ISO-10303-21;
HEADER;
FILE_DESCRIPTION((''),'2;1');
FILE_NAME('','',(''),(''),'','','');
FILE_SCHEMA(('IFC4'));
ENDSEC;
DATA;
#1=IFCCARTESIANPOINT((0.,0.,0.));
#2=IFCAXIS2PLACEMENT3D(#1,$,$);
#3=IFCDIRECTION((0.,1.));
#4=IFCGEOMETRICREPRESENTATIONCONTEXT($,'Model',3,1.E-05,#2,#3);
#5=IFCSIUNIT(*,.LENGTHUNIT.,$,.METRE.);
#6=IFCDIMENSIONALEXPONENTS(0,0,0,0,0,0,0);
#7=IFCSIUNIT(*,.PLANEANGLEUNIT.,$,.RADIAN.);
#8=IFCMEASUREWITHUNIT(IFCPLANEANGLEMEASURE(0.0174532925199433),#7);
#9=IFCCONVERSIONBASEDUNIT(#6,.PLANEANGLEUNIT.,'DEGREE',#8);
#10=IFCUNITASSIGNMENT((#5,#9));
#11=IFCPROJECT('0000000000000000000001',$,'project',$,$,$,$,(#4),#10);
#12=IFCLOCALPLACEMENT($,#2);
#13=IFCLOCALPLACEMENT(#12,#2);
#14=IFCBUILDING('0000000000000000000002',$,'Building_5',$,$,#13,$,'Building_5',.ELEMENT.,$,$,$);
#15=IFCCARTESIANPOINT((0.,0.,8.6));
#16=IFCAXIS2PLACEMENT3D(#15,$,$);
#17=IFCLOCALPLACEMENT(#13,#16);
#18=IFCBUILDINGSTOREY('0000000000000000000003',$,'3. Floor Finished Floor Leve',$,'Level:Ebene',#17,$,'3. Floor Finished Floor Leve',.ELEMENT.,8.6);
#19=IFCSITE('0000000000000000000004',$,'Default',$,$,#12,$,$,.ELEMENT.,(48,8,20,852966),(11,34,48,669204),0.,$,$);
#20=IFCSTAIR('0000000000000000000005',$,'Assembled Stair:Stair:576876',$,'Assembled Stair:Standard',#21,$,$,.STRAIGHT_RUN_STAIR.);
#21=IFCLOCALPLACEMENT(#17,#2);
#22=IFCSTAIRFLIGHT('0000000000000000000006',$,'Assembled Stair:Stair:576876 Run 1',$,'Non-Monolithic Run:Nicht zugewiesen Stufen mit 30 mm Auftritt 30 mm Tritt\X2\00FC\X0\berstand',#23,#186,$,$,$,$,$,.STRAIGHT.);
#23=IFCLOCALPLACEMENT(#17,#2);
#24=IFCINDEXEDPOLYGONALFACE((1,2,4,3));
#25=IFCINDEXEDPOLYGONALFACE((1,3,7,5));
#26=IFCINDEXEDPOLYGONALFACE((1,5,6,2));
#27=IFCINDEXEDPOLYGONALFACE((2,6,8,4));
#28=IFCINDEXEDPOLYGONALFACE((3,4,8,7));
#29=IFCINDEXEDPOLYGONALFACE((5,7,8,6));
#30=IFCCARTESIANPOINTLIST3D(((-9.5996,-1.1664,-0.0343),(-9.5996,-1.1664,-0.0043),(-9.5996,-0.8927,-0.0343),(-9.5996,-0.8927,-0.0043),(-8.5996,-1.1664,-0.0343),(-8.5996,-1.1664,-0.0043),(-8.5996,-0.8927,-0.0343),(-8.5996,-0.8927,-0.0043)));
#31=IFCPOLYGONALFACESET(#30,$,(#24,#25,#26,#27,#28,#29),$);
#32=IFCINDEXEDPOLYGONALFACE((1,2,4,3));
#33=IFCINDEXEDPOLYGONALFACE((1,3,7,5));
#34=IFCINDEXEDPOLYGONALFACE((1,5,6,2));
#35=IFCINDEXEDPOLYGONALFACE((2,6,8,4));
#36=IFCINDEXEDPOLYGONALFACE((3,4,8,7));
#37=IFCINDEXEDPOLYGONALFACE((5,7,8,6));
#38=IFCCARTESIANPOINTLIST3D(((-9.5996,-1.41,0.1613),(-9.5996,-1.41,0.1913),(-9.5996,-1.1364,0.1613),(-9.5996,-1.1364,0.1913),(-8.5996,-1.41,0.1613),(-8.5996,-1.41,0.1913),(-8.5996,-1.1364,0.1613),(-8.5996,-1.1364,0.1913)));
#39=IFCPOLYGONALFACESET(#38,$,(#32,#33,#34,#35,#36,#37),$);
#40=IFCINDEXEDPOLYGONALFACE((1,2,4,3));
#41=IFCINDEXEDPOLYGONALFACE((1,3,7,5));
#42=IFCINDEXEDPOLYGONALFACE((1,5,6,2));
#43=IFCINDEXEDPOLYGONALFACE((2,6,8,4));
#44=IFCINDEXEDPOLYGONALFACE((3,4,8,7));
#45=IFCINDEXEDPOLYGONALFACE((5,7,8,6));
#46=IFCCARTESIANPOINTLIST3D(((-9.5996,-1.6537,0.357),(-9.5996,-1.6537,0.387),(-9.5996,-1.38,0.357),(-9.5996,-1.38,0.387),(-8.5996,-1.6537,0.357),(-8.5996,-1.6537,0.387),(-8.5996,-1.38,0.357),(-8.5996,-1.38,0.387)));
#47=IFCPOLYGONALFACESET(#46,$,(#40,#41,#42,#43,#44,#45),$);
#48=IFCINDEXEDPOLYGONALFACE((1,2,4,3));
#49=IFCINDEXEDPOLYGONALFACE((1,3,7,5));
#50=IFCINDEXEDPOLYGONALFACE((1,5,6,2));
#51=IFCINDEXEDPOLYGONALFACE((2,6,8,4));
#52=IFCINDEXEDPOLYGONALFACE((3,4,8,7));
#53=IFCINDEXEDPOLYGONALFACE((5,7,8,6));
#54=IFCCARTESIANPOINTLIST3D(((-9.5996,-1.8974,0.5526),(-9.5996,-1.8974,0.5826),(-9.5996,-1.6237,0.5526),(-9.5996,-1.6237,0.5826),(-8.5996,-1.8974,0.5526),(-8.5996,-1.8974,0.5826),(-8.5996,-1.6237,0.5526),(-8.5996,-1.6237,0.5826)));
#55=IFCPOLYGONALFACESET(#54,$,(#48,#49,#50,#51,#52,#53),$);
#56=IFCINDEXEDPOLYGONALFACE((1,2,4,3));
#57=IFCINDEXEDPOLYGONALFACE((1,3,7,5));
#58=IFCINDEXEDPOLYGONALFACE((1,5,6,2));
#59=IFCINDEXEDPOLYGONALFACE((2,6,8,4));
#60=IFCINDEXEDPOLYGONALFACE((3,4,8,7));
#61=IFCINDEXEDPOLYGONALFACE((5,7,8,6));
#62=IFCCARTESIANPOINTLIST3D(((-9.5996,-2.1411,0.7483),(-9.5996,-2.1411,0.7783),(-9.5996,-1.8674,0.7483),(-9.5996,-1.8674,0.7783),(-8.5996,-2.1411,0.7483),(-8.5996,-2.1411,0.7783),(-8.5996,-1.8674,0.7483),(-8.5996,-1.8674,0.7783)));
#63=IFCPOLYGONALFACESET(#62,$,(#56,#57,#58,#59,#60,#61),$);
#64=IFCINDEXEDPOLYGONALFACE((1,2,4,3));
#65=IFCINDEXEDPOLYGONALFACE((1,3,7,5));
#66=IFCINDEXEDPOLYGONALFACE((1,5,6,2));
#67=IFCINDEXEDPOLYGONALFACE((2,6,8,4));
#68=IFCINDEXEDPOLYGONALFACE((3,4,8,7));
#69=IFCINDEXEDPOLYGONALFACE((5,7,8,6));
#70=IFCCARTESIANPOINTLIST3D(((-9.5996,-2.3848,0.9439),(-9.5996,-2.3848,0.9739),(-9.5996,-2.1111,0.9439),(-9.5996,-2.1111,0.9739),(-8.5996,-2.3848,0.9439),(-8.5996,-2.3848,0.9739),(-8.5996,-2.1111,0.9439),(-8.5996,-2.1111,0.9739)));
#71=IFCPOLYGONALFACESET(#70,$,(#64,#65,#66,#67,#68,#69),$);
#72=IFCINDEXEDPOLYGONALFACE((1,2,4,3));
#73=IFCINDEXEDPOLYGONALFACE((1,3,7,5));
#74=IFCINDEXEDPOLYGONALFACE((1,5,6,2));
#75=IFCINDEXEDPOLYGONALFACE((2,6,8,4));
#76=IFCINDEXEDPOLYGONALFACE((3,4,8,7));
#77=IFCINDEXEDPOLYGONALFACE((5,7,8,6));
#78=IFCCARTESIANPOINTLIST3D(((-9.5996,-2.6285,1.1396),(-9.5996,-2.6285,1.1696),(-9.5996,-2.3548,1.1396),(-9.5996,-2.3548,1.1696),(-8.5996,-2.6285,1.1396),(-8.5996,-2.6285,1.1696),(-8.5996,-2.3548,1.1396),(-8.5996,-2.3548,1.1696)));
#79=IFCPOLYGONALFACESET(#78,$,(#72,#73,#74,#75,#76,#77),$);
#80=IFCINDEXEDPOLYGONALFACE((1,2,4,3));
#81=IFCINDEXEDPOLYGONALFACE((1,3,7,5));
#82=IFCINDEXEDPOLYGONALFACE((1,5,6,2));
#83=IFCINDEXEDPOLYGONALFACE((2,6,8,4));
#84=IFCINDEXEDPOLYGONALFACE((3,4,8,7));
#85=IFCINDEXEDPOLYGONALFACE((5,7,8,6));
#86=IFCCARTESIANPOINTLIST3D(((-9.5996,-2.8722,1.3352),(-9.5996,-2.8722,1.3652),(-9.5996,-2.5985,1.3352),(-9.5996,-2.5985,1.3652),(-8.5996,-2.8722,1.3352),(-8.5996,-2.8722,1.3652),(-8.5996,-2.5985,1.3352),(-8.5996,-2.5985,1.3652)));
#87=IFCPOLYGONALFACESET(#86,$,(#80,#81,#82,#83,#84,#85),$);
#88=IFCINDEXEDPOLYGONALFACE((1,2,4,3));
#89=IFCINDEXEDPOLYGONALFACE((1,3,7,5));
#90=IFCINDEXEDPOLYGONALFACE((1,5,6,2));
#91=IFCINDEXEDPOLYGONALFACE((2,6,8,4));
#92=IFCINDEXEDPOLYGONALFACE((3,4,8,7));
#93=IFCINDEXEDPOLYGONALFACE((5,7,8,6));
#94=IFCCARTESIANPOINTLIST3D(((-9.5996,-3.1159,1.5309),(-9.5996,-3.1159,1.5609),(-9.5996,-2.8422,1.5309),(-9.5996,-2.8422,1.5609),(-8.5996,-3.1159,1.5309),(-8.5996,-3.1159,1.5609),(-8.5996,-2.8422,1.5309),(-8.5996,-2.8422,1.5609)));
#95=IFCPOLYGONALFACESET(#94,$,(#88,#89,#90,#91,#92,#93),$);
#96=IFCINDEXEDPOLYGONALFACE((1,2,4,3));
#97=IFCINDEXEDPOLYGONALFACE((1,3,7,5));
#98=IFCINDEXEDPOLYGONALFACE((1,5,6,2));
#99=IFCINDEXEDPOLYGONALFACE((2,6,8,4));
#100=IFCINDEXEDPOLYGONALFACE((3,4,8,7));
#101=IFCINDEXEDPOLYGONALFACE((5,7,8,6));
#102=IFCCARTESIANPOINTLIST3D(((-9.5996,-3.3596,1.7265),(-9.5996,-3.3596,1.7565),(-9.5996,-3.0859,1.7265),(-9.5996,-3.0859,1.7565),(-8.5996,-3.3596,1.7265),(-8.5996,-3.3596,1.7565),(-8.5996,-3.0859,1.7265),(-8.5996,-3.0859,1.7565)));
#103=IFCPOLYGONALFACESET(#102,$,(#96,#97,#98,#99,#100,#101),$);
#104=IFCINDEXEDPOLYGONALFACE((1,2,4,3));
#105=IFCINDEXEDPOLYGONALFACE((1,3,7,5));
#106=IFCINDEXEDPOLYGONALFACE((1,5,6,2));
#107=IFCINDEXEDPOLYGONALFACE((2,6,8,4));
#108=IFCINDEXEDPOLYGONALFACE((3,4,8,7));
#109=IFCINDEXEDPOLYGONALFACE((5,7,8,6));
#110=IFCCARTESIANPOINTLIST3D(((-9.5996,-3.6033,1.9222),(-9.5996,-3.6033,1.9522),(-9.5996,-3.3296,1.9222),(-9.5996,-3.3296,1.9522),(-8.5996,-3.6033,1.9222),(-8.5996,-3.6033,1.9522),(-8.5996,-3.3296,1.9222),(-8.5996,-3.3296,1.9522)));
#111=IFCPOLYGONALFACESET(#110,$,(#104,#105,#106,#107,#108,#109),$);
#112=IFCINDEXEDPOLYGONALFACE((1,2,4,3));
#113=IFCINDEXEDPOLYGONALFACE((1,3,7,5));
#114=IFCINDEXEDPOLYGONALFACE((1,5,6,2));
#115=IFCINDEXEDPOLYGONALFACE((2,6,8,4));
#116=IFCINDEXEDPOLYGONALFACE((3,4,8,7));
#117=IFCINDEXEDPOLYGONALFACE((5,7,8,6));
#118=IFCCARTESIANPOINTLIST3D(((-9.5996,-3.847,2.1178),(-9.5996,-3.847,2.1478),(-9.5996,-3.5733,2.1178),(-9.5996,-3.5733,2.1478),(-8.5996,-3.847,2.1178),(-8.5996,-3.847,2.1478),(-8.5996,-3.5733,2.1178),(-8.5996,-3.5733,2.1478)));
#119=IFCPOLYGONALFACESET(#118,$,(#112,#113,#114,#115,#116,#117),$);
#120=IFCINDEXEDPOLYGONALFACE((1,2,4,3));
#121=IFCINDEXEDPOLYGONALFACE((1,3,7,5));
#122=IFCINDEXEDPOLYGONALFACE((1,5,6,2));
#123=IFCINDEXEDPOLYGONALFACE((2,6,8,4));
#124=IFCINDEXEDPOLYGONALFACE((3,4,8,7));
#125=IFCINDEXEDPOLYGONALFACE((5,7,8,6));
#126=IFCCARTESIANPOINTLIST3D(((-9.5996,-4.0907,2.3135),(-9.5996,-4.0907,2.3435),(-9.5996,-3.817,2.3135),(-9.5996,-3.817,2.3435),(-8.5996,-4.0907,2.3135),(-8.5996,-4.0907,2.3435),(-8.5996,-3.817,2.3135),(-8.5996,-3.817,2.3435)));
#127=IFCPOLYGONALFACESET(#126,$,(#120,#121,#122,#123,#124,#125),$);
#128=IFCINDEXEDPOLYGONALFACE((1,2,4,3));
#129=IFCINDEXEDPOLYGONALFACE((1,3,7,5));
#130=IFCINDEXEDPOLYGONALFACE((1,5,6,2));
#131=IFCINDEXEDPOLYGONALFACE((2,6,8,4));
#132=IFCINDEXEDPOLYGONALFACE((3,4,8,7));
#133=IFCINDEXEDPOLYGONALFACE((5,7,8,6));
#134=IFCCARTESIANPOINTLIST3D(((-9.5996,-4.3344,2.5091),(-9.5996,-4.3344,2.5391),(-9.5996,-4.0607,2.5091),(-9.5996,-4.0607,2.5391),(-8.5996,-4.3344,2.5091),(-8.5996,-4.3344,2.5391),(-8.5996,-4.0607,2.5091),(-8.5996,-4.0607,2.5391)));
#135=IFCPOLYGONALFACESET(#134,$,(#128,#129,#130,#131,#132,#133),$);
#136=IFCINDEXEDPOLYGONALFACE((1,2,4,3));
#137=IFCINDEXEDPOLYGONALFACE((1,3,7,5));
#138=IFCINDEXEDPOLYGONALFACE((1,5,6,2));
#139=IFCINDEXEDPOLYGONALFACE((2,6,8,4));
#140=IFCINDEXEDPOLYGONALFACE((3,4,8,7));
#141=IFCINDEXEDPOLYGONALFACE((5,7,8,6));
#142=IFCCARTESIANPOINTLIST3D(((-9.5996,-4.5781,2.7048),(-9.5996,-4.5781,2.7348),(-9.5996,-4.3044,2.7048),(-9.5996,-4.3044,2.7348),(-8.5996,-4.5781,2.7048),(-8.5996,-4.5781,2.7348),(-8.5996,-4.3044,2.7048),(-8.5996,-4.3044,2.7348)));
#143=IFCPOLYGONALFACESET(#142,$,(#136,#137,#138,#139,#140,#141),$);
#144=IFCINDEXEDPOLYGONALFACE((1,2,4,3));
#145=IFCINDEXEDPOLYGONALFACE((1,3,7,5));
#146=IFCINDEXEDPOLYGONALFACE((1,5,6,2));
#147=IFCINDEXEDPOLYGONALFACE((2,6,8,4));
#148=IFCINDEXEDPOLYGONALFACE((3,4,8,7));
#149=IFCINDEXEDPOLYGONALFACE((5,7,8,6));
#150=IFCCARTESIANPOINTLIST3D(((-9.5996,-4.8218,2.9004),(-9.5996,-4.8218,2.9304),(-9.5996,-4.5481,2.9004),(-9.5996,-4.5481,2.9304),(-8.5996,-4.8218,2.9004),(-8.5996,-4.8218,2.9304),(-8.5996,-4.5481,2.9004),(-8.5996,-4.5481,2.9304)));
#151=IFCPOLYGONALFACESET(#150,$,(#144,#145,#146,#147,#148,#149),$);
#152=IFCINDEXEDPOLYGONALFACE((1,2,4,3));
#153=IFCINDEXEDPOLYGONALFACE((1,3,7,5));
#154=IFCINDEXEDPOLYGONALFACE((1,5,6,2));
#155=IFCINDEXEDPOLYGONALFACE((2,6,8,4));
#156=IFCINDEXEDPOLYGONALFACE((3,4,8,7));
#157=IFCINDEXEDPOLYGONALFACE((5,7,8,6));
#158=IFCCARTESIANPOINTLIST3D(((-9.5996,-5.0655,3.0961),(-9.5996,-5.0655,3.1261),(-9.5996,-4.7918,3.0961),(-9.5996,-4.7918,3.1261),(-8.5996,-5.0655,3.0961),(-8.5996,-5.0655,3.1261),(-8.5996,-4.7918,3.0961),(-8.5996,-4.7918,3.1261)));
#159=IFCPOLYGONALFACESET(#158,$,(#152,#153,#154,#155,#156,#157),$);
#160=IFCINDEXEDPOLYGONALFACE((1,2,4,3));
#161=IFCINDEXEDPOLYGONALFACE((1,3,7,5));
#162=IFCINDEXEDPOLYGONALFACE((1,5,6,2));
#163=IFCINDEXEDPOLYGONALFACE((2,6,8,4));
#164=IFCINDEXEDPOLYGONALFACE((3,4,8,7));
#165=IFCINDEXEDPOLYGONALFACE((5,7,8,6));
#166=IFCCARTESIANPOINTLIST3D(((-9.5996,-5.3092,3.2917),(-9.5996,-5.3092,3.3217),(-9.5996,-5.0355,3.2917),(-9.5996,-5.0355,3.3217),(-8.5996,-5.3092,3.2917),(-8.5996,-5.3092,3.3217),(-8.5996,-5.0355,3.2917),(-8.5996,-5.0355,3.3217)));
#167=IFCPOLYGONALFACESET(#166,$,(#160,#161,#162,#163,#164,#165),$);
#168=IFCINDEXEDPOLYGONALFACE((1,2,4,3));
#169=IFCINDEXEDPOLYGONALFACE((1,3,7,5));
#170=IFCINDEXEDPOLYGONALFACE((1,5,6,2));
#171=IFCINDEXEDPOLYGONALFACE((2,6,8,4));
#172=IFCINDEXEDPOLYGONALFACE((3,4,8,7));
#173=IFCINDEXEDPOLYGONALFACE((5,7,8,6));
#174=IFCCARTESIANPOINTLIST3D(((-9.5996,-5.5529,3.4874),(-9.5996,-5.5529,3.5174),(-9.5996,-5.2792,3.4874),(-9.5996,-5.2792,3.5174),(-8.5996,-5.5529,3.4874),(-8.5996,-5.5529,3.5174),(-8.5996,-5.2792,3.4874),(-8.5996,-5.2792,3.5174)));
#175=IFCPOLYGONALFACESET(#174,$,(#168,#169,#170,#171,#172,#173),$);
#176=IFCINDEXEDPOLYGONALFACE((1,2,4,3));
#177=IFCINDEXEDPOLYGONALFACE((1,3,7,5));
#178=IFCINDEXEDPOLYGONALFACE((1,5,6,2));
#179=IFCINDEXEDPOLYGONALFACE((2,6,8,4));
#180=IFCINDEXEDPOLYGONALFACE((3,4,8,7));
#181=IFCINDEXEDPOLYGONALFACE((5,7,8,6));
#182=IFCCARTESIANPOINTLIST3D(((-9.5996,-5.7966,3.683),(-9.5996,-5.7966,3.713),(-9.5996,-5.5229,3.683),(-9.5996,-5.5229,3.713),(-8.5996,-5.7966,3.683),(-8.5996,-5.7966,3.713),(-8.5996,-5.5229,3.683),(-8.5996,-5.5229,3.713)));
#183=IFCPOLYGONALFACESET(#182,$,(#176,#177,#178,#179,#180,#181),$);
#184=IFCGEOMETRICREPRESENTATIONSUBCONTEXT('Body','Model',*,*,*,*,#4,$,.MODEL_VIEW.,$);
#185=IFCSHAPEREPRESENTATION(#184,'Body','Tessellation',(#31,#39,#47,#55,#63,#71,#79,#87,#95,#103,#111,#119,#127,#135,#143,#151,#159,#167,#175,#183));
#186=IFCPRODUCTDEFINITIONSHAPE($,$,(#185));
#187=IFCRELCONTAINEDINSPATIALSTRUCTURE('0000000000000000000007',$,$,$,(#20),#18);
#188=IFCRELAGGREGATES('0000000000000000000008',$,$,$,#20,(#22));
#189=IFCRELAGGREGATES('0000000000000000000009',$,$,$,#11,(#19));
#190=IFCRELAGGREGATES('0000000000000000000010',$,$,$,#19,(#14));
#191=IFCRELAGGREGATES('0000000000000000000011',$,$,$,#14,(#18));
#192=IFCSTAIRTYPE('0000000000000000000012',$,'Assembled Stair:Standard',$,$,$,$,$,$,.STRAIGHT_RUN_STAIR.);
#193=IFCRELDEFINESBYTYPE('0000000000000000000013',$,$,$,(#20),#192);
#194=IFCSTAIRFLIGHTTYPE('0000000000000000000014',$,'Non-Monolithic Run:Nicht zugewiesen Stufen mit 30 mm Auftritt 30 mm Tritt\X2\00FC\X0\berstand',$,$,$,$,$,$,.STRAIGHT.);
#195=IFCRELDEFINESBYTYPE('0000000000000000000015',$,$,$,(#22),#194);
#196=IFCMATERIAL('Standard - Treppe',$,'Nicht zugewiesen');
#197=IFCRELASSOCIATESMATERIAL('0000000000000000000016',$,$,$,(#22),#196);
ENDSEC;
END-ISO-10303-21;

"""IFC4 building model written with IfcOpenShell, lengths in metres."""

from ifc_helpers import new_model, entity, si_unit, converted_unit, direction, frame, origin, place, context, subcontext, project, spatial, indexed_curve, outline, extrude, material, type_object, element, aggregate, save


model = new_model("IFC4")

# Units and contexts
model_context = context("Model", 3, precision=1e-05, world=origin(), true_north=direction((0.0, 1.0)))
body_context = subcontext(model_context, "Body", "Model", "MODEL_VIEW")
ifc_project = project(units=[si_unit("LENGTHUNIT", "METRE"), converted_unit("PLANEANGLEUNIT", "DEGREE", entity("IfcPlaneAngleMeasure", 0.0174532925199433), si_unit("PLANEANGLEUNIT", "RADIAN"), dimensions=[0, 0, 0, 0, 0, 0, 0])], contexts=[model_context])

# Site, building, storey
site_placement = place(None, origin())
site = spatial("IfcSite", under=ifc_project, at=site_placement, Name="Default", CompositionType="ELEMENT", RefLatitude=(48, 8, 20, 852966), RefLongitude=(11, 34, 48, 669204), RefElevation=0.0)
building_placement = place(site_placement, origin())
building = spatial("IfcBuilding", under=site, at=building_placement, Name="Building_5", LongName="Building_5", CompositionType="ELEMENT")
storey_placement = place(building_placement, frame((0.0, 0.0, 8.6)))
storey = spatial("IfcBuildingStorey", under=building, at=storey_placement, Name="3. Floor Finished Floor Leve", ObjectType="Level:Ebene", LongName="3. Floor Finished Floor Leve", CompositionType="ELEMENT", Elevation=8.6)

# Stair, stair flight
stair_type_1 = type_object("IfcStairType", Name="Assembled Stair:Standard", PredefinedType="STRAIGHT_RUN_STAIR")
stair_1_placement = place(storey_placement, origin())
stair_1 = element("IfcStair", 1, at=stair_1_placement, inside=storey, type_object=stair_type_1, Name="Assembled Stair:Stair:576876", ObjectType="Assembled Stair:Standard", PredefinedType="STRAIGHT_RUN_STAIR")
ifc_material_1 = material(Name="Standard - Treppe", Category="Nicht zugewiesen")
stair_flight_type_1 = type_object("IfcStairFlightType", Name="Non-Monolithic Run:Nicht zugewiesen Stufen mit 30 mm Auftritt 30 mm Trittüberstand", PredefinedType="STRAIGHT")
stair_flight_1_placement = place(stair_1_placement, origin())
stair_flight_1 = element("IfcStairFlight", 2, at=stair_flight_1_placement, type_object=stair_flight_type_1, material=ifc_material_1, Name="Assembled Stair:Stair:576876 Run 1", ObjectType="Non-Monolithic Run:Nicht zugewiesen Stufen mit 30 mm Auftritt 30 mm Trittüberstand", PredefinedType="STRAIGHT", context=body_context, shape_type="SweptSolid", body=[
    extrude(outline(indexed_curve([(-0.1368, -0.5), (0.1368, -0.5), (0.1368, 0.5), (-0.1368, 0.5), (-0.1368, -0.5)], self_intersect=False)), frame((-9.0996, -1.0295, -0.0343), z_axis=(0.0, 0.0, 1.0), x_axis=(0.0, 1.0, 0.0)), (0.0, 0.0, 1.0), 0.03),
    extrude(outline(indexed_curve([(-0.1368, -0.5), (0.1368, -0.5), (0.1368, 0.5), (-0.1368, 0.5), (-0.1368, -0.5)], self_intersect=False)), frame((-9.0996, -1.2732, 0.1613), z_axis=(0.0, 0.0, 1.0), x_axis=(0.0, 1.0, 0.0)), (0.0, 0.0, 1.0), 0.03),
    extrude(outline(indexed_curve([(-0.1368, -0.5), (0.1368, -0.5), (0.1368, 0.5), (-0.1368, 0.5), (-0.1368, -0.5)], self_intersect=False)), frame((-9.0996, -1.5169, 0.357), z_axis=(0.0, 0.0, 1.0), x_axis=(0.0, 1.0, 0.0)), (0.0, 0.0, 1.0), 0.03),
    extrude(outline(indexed_curve([(-0.1368, -0.5), (0.1368, -0.5), (0.1368, 0.5), (-0.1368, 0.5), (-0.1368, -0.5)], self_intersect=False)), frame((-9.0996, -1.7606, 0.5526), z_axis=(0.0, 0.0, 1.0), x_axis=(0.0, 1.0, 0.0)), (0.0, 0.0, 1.0), 0.03),
    extrude(outline(indexed_curve([(-0.1368, -0.5), (0.1368, -0.5), (0.1368, 0.5), (-0.1368, 0.5), (-0.1368, -0.5)], self_intersect=False)), frame((-9.0996, -2.0043, 0.7483), z_axis=(0.0, 0.0, 1.0), x_axis=(0.0, 1.0, 0.0)), (0.0, 0.0, 1.0), 0.03),
    extrude(outline(indexed_curve([(-0.1368, -0.5), (0.1368, -0.5), (0.1368, 0.5), (-0.1368, 0.5), (-0.1368, -0.5)], self_intersect=False)), frame((-9.0996, -2.248, 0.9439), z_axis=(0.0, 0.0, 1.0), x_axis=(0.0, 1.0, 0.0)), (0.0, 0.0, 1.0), 0.03),
    extrude(outline(indexed_curve([(-0.1368, -0.5), (0.1368, -0.5), (0.1368, 0.5), (-0.1368, 0.5), (-0.1368, -0.5)], self_intersect=False)), frame((-9.0996, -2.4917, 1.1396), z_axis=(0.0, 0.0, 1.0), x_axis=(0.0, 1.0, 0.0)), (0.0, 0.0, 1.0), 0.03),
    extrude(outline(indexed_curve([(-0.1368, -0.5), (0.1368, -0.5), (0.1368, 0.5), (-0.1368, 0.5), (-0.1368, -0.5)], self_intersect=False)), frame((-9.0996, -2.7354, 1.3352), z_axis=(0.0, 0.0, 1.0), x_axis=(0.0, 1.0, 0.0)), (0.0, 0.0, 1.0), 0.03),
    extrude(outline(indexed_curve([(-0.1368, -0.5), (0.1368, -0.5), (0.1368, 0.5), (-0.1368, 0.5), (-0.1368, -0.5)], self_intersect=False)), frame((-9.0996, -2.9791, 1.5309), z_axis=(0.0, 0.0, 1.0), x_axis=(0.0, 1.0, 0.0)), (0.0, 0.0, 1.0), 0.03),
    extrude(outline(indexed_curve([(-0.1368, -0.5), (0.1368, -0.5), (0.1368, 0.5), (-0.1368, 0.5), (-0.1368, -0.5)], self_intersect=False)), frame((-9.0996, -3.2228, 1.7265), z_axis=(0.0, 0.0, 1.0), x_axis=(0.0, 1.0, 0.0)), (0.0, 0.0, 1.0), 0.03),
    extrude(outline(indexed_curve([(-0.1368, -0.5), (0.1368, -0.5), (0.1368, 0.5), (-0.1368, 0.5), (-0.1368, -0.5)], self_intersect=False)), frame((-9.0996, -3.4665, 1.9222), z_axis=(0.0, 0.0, 1.0), x_axis=(0.0, 1.0, 0.0)), (0.0, 0.0, 1.0), 0.03),
    extrude(outline(indexed_curve([(-0.1368, -0.5), (0.1368, -0.5), (0.1368, 0.5), (-0.1368, 0.5), (-0.1368, -0.5)], self_intersect=False)), frame((-9.0996, -3.7102, 2.1178), z_axis=(0.0, 0.0, 1.0), x_axis=(0.0, 1.0, 0.0)), (0.0, 0.0, 1.0), 0.03),
    extrude(outline(indexed_curve([(-0.1368, -0.5), (0.1368, -0.5), (0.1368, 0.5), (-0.1368, 0.5), (-0.1368, -0.5)], self_intersect=False)), frame((-9.0996, -3.9539, 2.3135), z_axis=(0.0, 0.0, 1.0), x_axis=(0.0, 1.0, 0.0)), (0.0, 0.0, 1.0), 0.03),
    extrude(outline(indexed_curve([(-0.1368, -0.5), (0.1368, -0.5), (0.1368, 0.5), (-0.1368, 0.5), (-0.1368, -0.5)], self_intersect=False)), frame((-9.0996, -4.1975, 2.5091), z_axis=(0.0, 0.0, 1.0), x_axis=(0.0, 1.0, 0.0)), (0.0, 0.0, 1.0), 0.03),
    extrude(outline(indexed_curve([(-0.1368, -0.5), (0.1368, -0.5), (0.1368, 0.5), (-0.1368, 0.5), (-0.1368, -0.5)], self_intersect=False)), frame((-9.0996, -4.4412, 2.7048), z_axis=(0.0, 0.0, 1.0), x_axis=(0.0, 1.0, 0.0)), (0.0, 0.0, 1.0), 0.03),
    extrude(outline(indexed_curve([(-0.1368, -0.5), (0.1368, -0.5), (0.1368, 0.5), (-0.1368, 0.5), (-0.1368, -0.5)], self_intersect=False)), frame((-9.0996, -4.6849, 2.9004), z_axis=(0.0, 0.0, 1.0), x_axis=(0.0, 1.0, 0.0)), (0.0, 0.0, 1.0), 0.03),
    extrude(outline(indexed_curve([(-0.1368, -0.5), (0.1368, -0.5), (0.1368, 0.5), (-0.1368, 0.5), (-0.1368, -0.5)], self_intersect=False)), frame((-9.0996, -4.9286, 3.0961), z_axis=(0.0, 0.0, 1.0), x_axis=(0.0, 1.0, 0.0)), (0.0, 0.0, 1.0), 0.03),
    extrude(outline(indexed_curve([(-0.1368, -0.5), (0.1368, -0.5), (0.1368, 0.5), (-0.1368, 0.5), (-0.1368, -0.5)], self_intersect=False)), frame((-9.0996, -5.1723, 3.2917), z_axis=(0.0, 0.0, 1.0), x_axis=(0.0, 1.0, 0.0)), (0.0, 0.0, 1.0), 0.03),
    extrude(outline(indexed_curve([(-0.1368, -0.5), (0.1368, -0.5), (0.1368, 0.5), (-0.1368, 0.5), (-0.1368, -0.5)], self_intersect=False)), frame((-9.0996, -5.416, 3.4874), z_axis=(0.0, 0.0, 1.0), x_axis=(0.0, 1.0, 0.0)), (0.0, 0.0, 1.0), 0.03),
    extrude(outline(indexed_curve([(-0.1368, -0.5), (0.1368, -0.5), (0.1368, 0.5), (-0.1368, 0.5), (-0.1368, -0.5)], self_intersect=False)), frame((-9.0996, -5.6597, 3.683), z_axis=(0.0, 0.0, 1.0), x_axis=(0.0, 1.0, 0.0)), (0.0, 0.0, 1.0), 0.03),
])
aggregate(stair_1, [stair_flight_1])

save(model, "model.ifc")
